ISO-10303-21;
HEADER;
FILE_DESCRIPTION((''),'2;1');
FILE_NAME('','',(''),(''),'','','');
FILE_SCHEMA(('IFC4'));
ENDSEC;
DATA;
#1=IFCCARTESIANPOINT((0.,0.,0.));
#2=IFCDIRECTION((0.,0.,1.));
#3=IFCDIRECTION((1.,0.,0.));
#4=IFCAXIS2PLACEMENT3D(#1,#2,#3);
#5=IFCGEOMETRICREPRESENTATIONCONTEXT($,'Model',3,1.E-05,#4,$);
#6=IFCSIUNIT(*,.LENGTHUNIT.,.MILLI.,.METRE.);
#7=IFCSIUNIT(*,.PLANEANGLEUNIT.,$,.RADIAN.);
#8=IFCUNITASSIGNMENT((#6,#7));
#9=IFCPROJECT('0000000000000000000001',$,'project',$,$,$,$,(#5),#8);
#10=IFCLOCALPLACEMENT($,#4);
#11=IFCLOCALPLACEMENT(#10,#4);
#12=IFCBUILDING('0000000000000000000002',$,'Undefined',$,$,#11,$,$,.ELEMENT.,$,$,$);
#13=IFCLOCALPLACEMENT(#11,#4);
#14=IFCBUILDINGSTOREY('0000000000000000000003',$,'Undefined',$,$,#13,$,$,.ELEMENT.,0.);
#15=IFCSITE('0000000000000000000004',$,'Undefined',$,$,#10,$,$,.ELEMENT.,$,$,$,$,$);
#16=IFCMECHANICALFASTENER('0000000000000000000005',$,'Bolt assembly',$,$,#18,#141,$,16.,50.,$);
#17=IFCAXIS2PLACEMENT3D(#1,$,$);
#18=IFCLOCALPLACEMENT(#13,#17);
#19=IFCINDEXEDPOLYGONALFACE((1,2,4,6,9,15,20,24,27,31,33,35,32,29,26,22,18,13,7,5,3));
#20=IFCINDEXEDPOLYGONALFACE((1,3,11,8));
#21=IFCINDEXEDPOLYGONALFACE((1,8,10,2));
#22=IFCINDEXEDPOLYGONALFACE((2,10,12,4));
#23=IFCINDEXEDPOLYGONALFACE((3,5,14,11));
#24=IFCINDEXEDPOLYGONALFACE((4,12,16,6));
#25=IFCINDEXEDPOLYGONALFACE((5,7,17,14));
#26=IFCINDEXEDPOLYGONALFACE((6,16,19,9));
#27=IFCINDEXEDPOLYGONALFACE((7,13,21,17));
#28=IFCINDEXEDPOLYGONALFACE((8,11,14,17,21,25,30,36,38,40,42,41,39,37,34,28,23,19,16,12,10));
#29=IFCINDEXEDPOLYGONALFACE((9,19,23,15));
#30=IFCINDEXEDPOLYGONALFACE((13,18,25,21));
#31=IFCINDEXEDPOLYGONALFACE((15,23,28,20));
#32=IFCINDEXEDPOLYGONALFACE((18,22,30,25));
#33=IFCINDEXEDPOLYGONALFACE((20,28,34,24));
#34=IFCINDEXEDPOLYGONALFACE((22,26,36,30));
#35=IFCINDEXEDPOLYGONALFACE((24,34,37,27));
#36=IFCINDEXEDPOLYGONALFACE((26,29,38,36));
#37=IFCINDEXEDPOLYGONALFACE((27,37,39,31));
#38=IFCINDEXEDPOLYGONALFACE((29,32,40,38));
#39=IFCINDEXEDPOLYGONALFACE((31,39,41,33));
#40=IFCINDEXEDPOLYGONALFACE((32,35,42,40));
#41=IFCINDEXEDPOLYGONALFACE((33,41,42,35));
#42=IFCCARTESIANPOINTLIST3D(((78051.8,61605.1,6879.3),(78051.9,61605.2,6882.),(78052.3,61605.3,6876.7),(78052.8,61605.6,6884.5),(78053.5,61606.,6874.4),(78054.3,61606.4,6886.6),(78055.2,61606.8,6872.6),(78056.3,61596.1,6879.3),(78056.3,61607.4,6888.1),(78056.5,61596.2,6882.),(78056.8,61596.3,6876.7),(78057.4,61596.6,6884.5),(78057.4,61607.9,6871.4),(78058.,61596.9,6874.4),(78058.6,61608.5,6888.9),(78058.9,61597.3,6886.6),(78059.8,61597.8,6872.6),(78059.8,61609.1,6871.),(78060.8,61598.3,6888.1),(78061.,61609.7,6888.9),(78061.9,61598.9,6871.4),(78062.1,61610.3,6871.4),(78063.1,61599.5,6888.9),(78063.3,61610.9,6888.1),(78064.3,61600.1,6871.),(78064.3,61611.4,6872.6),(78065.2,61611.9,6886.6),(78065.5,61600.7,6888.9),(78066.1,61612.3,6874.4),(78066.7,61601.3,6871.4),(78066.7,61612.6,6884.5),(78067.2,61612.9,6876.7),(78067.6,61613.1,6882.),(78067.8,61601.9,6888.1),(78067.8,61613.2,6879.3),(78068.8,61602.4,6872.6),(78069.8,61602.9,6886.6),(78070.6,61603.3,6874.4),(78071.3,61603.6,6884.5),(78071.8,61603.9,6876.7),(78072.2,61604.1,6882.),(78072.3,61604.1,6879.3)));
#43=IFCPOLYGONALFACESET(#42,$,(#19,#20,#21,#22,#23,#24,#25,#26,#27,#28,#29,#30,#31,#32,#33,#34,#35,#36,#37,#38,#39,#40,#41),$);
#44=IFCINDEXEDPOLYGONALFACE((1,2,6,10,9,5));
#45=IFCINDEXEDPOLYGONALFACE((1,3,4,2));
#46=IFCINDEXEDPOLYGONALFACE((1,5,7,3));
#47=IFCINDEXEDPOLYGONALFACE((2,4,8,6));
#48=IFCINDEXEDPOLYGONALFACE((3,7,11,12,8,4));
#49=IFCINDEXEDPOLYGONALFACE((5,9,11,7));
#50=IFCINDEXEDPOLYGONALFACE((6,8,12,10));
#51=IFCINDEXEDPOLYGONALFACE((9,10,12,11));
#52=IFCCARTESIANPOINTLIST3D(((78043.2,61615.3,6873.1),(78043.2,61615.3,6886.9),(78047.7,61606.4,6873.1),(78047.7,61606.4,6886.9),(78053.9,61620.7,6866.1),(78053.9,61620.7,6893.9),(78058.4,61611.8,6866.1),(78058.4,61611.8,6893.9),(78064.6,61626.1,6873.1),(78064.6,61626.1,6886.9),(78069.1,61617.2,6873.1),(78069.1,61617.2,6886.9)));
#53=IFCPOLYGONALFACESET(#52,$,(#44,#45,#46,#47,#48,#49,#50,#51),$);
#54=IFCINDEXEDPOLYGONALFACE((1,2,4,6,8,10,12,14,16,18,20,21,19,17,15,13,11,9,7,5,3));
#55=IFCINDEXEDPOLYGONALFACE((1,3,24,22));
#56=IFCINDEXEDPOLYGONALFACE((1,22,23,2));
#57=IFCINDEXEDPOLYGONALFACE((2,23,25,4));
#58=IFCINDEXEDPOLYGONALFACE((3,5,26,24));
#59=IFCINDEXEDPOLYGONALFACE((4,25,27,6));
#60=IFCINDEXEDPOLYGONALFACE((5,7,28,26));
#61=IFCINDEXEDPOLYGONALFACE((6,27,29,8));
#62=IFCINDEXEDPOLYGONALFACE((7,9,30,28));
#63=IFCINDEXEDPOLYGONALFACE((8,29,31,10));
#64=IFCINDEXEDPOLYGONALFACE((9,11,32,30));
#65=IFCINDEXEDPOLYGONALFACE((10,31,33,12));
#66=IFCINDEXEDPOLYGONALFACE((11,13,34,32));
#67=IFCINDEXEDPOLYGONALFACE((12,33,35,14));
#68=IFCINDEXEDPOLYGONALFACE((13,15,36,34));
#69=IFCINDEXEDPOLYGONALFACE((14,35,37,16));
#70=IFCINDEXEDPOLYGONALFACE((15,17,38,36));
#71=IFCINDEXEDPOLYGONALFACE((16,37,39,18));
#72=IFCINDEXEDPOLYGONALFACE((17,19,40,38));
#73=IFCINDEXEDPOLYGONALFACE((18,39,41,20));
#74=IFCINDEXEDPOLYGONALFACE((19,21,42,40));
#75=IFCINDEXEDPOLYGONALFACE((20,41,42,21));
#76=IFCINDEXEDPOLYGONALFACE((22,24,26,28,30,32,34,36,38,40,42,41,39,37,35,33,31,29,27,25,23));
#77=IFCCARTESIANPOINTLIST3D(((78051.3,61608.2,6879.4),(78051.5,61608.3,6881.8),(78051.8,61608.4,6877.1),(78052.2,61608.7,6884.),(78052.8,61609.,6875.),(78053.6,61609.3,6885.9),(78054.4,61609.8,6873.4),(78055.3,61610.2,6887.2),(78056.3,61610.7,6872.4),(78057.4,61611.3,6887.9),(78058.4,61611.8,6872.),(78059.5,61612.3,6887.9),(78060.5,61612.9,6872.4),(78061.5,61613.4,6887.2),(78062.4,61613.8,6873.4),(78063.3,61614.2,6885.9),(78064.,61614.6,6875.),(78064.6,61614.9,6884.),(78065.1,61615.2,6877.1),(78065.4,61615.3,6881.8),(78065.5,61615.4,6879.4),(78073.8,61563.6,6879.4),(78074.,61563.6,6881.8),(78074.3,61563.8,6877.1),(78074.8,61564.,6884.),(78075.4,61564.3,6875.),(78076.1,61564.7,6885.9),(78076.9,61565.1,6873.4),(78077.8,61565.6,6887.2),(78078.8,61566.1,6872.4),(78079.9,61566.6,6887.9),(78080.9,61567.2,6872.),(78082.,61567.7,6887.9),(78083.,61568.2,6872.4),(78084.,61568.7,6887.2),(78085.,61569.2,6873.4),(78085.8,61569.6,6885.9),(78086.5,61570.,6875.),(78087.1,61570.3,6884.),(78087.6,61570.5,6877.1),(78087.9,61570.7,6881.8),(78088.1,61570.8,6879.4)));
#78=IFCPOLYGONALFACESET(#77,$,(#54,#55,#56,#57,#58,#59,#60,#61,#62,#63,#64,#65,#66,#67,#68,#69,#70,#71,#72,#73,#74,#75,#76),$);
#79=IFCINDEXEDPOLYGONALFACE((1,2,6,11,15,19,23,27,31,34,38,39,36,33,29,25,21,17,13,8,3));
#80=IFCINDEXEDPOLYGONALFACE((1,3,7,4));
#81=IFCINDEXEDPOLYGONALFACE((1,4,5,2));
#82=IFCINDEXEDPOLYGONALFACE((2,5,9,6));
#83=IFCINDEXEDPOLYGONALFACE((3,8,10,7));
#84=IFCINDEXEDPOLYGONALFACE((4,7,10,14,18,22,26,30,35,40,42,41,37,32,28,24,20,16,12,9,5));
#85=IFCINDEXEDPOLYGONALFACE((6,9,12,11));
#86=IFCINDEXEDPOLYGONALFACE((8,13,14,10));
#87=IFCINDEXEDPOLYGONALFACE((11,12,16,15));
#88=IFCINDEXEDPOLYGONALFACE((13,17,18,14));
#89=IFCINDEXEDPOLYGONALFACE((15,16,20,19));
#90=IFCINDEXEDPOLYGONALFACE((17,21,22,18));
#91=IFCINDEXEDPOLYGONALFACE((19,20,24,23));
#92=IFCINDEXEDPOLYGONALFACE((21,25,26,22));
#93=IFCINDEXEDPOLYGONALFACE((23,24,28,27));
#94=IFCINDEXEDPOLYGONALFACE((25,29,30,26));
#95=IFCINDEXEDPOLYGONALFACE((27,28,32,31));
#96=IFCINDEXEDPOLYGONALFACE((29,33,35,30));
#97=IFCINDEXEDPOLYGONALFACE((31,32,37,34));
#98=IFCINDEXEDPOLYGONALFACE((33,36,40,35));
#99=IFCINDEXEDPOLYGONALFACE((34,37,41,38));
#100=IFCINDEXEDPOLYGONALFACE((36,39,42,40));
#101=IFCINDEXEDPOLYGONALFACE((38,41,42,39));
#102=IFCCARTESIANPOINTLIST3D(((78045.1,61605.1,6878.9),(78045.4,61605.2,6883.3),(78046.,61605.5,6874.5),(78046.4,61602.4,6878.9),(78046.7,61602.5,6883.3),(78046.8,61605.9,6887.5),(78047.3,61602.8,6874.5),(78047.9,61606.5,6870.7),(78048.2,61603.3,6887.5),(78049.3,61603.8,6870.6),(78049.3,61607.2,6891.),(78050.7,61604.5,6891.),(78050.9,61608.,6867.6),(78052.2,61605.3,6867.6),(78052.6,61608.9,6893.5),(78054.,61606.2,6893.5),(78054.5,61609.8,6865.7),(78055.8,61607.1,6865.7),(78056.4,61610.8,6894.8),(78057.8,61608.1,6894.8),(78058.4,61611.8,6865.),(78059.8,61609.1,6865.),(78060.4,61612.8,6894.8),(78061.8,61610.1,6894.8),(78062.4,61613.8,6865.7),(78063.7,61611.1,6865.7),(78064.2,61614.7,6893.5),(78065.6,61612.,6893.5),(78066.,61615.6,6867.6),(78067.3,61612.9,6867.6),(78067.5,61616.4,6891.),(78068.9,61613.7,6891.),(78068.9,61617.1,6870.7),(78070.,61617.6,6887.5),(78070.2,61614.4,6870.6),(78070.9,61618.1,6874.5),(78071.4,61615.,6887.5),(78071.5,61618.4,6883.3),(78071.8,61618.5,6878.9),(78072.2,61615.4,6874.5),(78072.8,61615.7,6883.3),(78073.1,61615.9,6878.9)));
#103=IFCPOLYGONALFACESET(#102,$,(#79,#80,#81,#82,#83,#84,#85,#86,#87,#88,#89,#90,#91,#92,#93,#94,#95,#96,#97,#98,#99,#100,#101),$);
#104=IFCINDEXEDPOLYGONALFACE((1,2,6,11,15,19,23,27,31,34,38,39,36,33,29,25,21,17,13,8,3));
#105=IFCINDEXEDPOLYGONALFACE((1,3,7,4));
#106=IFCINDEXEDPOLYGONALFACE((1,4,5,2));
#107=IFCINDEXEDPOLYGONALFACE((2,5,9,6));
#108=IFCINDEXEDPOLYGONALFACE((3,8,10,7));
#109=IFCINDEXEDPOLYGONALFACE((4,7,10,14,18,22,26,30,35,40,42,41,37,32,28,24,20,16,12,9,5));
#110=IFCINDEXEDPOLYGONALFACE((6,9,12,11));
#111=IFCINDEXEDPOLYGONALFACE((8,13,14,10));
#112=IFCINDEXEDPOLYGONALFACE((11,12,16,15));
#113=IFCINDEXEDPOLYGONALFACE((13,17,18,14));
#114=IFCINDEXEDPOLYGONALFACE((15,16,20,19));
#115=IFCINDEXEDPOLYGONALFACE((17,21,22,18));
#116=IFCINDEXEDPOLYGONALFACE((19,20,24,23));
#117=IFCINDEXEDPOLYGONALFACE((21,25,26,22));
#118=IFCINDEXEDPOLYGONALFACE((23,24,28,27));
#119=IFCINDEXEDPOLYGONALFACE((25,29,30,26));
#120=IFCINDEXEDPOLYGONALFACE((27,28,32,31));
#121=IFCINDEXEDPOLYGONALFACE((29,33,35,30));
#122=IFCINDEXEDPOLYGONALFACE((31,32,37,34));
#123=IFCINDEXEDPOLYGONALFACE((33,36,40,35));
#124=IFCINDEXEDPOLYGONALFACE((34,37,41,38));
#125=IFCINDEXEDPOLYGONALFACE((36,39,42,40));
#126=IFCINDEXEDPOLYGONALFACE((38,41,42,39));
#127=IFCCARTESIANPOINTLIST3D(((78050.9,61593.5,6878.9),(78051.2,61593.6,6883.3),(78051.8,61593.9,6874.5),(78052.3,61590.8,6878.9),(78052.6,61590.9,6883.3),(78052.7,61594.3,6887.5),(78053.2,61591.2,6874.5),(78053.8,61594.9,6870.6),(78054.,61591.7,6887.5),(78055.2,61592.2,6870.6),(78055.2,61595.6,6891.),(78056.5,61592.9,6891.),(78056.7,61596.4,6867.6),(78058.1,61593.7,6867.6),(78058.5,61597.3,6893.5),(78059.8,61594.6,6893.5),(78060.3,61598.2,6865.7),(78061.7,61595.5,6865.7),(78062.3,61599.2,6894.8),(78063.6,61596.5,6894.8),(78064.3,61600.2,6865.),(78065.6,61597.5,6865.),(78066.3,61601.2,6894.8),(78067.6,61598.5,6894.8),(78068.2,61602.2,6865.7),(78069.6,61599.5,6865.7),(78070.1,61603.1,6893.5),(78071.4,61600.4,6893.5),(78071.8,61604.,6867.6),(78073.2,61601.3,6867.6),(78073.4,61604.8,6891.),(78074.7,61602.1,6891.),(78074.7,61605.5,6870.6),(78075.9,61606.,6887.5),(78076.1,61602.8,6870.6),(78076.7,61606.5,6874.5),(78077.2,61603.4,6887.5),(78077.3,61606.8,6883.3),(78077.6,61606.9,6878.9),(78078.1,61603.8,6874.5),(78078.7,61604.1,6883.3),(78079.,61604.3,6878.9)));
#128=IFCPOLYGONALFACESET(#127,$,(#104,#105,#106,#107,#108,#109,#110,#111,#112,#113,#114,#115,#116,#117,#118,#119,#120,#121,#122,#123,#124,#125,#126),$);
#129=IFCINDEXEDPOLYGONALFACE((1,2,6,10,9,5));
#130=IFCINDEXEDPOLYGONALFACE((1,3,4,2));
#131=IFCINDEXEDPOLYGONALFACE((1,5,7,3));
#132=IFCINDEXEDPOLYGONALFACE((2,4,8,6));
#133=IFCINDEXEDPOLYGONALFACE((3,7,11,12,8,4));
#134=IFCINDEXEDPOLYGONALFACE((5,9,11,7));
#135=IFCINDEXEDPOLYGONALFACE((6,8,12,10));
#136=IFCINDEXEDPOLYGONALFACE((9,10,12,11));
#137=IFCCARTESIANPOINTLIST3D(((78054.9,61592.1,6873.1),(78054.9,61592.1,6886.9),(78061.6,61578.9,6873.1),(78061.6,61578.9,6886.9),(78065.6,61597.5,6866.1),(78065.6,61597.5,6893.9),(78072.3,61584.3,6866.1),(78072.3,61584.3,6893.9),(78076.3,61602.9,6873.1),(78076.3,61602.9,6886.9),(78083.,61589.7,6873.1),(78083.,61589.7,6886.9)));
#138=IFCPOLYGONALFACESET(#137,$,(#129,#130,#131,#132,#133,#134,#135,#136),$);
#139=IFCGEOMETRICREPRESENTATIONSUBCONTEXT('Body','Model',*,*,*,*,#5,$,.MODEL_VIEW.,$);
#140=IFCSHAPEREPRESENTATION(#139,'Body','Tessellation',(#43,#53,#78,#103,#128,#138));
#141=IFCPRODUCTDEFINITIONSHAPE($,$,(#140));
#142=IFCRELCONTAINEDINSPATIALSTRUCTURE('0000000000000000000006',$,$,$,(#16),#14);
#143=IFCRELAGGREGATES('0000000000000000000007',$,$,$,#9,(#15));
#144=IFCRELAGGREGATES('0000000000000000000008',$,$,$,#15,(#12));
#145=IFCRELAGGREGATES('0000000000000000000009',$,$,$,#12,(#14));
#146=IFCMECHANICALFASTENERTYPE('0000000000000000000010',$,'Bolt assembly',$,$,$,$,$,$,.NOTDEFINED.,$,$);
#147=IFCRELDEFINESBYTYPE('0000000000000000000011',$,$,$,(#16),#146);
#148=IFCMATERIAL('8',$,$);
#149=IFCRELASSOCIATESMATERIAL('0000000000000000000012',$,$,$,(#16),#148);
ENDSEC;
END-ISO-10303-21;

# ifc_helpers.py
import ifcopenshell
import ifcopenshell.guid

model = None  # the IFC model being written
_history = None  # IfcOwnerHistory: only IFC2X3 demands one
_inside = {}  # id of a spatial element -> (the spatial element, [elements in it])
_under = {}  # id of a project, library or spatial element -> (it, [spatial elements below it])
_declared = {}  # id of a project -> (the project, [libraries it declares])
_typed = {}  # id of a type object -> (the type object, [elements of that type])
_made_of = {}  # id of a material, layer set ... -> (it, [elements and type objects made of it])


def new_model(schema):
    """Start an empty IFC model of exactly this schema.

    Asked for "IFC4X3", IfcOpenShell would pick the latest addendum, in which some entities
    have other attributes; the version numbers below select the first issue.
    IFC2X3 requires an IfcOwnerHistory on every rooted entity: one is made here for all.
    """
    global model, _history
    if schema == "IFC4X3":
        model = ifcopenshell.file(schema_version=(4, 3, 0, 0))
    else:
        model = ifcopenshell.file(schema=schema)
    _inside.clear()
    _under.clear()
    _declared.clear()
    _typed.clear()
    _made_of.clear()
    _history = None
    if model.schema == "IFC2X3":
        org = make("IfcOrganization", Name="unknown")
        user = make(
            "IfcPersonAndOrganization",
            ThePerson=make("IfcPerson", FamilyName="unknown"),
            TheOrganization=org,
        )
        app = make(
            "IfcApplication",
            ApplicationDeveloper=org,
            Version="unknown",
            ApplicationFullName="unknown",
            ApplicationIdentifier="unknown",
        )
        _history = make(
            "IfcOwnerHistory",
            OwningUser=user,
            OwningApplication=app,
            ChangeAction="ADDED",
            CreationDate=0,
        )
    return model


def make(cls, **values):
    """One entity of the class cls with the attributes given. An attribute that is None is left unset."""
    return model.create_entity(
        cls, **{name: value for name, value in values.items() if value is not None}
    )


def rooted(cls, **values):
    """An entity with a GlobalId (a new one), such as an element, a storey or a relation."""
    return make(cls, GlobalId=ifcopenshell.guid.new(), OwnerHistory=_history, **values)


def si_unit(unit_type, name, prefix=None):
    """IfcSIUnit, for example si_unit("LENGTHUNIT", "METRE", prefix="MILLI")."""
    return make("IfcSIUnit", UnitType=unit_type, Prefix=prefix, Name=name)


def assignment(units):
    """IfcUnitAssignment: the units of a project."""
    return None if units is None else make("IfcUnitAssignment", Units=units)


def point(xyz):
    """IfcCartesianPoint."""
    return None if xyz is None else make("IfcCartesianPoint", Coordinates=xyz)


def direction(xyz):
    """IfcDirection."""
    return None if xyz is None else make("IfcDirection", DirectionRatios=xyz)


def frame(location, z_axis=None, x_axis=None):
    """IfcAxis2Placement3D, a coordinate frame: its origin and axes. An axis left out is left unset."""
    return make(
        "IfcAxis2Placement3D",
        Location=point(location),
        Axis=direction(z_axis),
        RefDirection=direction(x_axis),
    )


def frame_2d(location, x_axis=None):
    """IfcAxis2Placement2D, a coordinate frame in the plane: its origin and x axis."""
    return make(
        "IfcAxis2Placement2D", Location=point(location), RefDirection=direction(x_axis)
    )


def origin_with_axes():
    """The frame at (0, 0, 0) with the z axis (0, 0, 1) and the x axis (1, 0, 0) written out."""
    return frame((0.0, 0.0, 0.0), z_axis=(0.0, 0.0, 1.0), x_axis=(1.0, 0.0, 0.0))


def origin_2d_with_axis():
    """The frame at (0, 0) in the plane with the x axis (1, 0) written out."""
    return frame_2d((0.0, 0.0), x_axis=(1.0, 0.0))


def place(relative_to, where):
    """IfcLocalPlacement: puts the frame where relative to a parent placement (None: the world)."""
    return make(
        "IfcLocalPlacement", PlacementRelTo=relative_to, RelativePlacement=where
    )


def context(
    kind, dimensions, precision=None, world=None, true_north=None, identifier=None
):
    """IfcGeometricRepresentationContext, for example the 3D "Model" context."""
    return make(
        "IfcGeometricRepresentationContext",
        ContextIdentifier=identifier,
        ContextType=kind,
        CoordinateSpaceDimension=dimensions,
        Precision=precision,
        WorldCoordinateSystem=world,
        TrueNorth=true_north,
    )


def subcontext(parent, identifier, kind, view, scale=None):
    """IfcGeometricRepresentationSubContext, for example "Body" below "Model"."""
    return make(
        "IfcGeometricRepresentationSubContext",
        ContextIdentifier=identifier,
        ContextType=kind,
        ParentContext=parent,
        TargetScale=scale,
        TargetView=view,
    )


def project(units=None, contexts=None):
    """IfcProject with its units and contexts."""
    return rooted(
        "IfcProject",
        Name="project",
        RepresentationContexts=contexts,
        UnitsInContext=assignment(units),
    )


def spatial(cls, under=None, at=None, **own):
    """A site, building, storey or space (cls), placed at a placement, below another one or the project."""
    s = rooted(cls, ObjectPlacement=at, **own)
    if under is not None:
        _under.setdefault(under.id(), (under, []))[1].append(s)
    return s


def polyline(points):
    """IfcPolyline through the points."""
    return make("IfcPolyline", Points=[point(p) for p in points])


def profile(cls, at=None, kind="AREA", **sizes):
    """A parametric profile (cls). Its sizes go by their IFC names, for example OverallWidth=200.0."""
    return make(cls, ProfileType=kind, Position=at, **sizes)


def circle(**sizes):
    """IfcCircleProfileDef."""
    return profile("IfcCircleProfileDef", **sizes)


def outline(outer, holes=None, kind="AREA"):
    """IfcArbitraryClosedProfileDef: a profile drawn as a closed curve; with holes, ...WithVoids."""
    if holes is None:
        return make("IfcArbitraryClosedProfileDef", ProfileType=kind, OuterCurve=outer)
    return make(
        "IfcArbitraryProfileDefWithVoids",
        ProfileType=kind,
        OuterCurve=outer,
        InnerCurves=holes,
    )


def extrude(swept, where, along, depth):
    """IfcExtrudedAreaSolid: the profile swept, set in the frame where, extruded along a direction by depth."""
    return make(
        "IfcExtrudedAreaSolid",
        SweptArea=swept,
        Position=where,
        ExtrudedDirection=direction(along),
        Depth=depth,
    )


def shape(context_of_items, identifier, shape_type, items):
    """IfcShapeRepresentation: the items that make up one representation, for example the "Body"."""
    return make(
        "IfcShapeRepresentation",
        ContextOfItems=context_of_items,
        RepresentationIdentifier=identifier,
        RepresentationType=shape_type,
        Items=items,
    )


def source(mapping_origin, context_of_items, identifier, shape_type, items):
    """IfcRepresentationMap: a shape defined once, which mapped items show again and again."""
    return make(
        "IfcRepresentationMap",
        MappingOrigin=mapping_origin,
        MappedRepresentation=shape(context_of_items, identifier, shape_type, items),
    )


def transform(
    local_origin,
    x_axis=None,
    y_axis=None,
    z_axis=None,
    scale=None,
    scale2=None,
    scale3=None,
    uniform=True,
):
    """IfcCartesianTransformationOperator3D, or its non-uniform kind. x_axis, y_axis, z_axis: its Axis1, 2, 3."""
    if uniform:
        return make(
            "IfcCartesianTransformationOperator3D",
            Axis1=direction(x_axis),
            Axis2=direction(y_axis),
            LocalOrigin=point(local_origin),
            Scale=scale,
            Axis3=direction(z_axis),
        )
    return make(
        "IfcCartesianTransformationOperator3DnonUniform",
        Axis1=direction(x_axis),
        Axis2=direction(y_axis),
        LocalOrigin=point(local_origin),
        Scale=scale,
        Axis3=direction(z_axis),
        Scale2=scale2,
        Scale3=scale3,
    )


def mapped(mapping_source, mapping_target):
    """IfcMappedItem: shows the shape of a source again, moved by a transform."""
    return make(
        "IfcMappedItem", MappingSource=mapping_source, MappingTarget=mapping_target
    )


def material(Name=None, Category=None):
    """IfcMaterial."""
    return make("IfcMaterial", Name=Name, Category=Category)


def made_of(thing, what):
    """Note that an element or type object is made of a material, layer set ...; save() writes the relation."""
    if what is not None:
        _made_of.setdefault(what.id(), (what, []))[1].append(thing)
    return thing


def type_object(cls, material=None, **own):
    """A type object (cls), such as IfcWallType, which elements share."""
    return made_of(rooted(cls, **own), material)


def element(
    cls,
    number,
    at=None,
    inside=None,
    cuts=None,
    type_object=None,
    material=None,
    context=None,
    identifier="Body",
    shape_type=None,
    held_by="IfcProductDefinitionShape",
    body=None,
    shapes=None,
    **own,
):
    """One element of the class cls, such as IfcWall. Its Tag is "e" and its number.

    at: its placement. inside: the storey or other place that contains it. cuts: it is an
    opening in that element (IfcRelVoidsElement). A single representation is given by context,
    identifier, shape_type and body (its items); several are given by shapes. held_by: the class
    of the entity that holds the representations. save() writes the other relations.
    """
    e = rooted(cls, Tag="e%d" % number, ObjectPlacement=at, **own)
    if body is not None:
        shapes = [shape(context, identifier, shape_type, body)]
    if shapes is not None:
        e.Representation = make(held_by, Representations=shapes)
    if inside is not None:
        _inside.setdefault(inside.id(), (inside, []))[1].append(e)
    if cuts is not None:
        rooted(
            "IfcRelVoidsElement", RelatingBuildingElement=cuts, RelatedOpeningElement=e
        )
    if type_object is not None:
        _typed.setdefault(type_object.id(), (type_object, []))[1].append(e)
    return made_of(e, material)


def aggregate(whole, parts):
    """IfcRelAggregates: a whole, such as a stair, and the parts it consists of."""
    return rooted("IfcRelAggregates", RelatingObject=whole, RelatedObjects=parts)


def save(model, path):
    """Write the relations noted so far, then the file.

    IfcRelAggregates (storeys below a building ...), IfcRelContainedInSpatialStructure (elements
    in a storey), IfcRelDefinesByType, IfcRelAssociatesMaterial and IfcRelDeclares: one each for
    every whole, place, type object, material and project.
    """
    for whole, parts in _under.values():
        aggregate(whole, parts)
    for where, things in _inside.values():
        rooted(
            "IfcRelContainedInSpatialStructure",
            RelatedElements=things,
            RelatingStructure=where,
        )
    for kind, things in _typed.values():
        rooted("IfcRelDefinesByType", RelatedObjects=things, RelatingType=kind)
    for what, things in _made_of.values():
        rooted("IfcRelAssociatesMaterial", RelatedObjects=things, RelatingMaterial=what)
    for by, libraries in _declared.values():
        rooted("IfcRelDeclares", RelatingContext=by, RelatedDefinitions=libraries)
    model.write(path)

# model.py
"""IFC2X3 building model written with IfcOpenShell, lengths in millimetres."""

from ifc_helpers import new_model, si_unit, frame, origin_with_axes, origin_2d_with_axis, place, context, subcontext, project, spatial, polyline, circle, outline, extrude, source, transform, mapped, material, type_object, element, save


model = new_model("IFC2X3")

# Units and contexts
model_context = context("Model", 3, precision=1e-05, world=origin_with_axes())
body_context = subcontext(model_context, "Body", "Model", "MODEL_VIEW")
ifc_project = project(units=[si_unit("LENGTHUNIT", "METRE", prefix="MILLI"), si_unit("PLANEANGLEUNIT", "RADIAN")], contexts=[model_context])

# Site, building, storey
site_placement = place(None, origin_with_axes())
site = spatial("IfcSite", under=ifc_project, at=site_placement, Name="Undefined", CompositionType="ELEMENT")
building_placement = place(site_placement, origin_with_axes())
building = spatial("IfcBuilding", under=site, at=building_placement, Name="Undefined", CompositionType="ELEMENT")
storey_placement = place(building_placement, origin_with_axes())
storey = spatial("IfcBuildingStorey", under=building, at=storey_placement, Name="Undefined", CompositionType="ELEMENT", Elevation=0.0)

# Mechanical fastener
ifc_material_1 = material(Name="8")
mechanical_fastener_type = type_object("IfcMechanicalFastenerType", Name="Bolt assembly")
shared_shape_1 = source(origin_with_axes(), body_context, "Body", "SweptSolid", [
    extrude(circle(Radius=9.0, at=origin_2d_with_axis()), frame((0.0, -40.4, 0.0), z_axis=(0.0, 1.0, 0.0), x_axis=(1.0, 0.0, 0.0)), (0.0, 0.0, 1.0), 10.1),
    extrude(outline(polyline([(13.9, 0.0), (6.9, 12.0), (-6.9, 12.0), (-13.9, 0.0), (-6.9, -12.0), (6.9, -12.0), (13.9, 0.0)])), frame((0.0, -53.4, 0.0), z_axis=(0.0, 1.0, 0.0), x_axis=(1.0, 0.0, 0.0)), (0.0, 0.0, 1.0), 10.0),
    extrude(circle(Radius=8.0, at=origin_2d_with_axis()), frame((0.0, -43.4, 0.0), z_axis=(0.0, 1.0, 0.0), x_axis=(1.0, 0.0, 0.0)), (0.0, 0.0, 1.0), 50.0),
    extrude(circle(Radius=15.0, at=origin_2d_with_axis()), frame((0.0, -43.4, 0.0), z_axis=(0.0, 1.0, 0.0), x_axis=(1.0, 0.0, 0.0)), (0.0, 0.0, 1.0), 3.0),
    extrude(circle(Radius=15.0, at=origin_2d_with_axis()), frame((0.0, -30.4, 0.0), z_axis=(0.0, 1.0, 0.0), x_axis=(1.0, 0.0, 0.0)), (0.0, 0.0, 1.0), 3.0),
    extrude(outline(polyline([(13.9, 0.0), (6.9, 12.0), (-6.9, 12.0), (-13.9, 0.0), (-6.9, -12.0), (6.9, -12.0), (13.9, 0.0)])), frame((0.0, -27.4, 0.0), z_axis=(0.0, 1.0, 0.0), x_axis=(1.0, 0.0, 0.0)), (0.0, 0.0, 1.0), 14.8),
])
mechanical_fastener_1_placement = place(storey_placement, frame((78078.0, 61573.1, 6880.0), z_axis=(-0.892821, -0.450411, 0.0), x_axis=(-0.000057, 0.000114, -1.0)))
element("IfcMechanicalFastener", 1, at=mechanical_fastener_1_placement, inside=storey, type_object=mechanical_fastener_type, material=ifc_material_1, Name="Bolt assembly", NominalDiameter=16.0, NominalLength=50.0, context=body_context, shape_type="MappedRepresentation", body=[
    mapped(shared_shape_1, transform((0.0, 0.0, 0.0))),
])

save(model, "model.ifc")
